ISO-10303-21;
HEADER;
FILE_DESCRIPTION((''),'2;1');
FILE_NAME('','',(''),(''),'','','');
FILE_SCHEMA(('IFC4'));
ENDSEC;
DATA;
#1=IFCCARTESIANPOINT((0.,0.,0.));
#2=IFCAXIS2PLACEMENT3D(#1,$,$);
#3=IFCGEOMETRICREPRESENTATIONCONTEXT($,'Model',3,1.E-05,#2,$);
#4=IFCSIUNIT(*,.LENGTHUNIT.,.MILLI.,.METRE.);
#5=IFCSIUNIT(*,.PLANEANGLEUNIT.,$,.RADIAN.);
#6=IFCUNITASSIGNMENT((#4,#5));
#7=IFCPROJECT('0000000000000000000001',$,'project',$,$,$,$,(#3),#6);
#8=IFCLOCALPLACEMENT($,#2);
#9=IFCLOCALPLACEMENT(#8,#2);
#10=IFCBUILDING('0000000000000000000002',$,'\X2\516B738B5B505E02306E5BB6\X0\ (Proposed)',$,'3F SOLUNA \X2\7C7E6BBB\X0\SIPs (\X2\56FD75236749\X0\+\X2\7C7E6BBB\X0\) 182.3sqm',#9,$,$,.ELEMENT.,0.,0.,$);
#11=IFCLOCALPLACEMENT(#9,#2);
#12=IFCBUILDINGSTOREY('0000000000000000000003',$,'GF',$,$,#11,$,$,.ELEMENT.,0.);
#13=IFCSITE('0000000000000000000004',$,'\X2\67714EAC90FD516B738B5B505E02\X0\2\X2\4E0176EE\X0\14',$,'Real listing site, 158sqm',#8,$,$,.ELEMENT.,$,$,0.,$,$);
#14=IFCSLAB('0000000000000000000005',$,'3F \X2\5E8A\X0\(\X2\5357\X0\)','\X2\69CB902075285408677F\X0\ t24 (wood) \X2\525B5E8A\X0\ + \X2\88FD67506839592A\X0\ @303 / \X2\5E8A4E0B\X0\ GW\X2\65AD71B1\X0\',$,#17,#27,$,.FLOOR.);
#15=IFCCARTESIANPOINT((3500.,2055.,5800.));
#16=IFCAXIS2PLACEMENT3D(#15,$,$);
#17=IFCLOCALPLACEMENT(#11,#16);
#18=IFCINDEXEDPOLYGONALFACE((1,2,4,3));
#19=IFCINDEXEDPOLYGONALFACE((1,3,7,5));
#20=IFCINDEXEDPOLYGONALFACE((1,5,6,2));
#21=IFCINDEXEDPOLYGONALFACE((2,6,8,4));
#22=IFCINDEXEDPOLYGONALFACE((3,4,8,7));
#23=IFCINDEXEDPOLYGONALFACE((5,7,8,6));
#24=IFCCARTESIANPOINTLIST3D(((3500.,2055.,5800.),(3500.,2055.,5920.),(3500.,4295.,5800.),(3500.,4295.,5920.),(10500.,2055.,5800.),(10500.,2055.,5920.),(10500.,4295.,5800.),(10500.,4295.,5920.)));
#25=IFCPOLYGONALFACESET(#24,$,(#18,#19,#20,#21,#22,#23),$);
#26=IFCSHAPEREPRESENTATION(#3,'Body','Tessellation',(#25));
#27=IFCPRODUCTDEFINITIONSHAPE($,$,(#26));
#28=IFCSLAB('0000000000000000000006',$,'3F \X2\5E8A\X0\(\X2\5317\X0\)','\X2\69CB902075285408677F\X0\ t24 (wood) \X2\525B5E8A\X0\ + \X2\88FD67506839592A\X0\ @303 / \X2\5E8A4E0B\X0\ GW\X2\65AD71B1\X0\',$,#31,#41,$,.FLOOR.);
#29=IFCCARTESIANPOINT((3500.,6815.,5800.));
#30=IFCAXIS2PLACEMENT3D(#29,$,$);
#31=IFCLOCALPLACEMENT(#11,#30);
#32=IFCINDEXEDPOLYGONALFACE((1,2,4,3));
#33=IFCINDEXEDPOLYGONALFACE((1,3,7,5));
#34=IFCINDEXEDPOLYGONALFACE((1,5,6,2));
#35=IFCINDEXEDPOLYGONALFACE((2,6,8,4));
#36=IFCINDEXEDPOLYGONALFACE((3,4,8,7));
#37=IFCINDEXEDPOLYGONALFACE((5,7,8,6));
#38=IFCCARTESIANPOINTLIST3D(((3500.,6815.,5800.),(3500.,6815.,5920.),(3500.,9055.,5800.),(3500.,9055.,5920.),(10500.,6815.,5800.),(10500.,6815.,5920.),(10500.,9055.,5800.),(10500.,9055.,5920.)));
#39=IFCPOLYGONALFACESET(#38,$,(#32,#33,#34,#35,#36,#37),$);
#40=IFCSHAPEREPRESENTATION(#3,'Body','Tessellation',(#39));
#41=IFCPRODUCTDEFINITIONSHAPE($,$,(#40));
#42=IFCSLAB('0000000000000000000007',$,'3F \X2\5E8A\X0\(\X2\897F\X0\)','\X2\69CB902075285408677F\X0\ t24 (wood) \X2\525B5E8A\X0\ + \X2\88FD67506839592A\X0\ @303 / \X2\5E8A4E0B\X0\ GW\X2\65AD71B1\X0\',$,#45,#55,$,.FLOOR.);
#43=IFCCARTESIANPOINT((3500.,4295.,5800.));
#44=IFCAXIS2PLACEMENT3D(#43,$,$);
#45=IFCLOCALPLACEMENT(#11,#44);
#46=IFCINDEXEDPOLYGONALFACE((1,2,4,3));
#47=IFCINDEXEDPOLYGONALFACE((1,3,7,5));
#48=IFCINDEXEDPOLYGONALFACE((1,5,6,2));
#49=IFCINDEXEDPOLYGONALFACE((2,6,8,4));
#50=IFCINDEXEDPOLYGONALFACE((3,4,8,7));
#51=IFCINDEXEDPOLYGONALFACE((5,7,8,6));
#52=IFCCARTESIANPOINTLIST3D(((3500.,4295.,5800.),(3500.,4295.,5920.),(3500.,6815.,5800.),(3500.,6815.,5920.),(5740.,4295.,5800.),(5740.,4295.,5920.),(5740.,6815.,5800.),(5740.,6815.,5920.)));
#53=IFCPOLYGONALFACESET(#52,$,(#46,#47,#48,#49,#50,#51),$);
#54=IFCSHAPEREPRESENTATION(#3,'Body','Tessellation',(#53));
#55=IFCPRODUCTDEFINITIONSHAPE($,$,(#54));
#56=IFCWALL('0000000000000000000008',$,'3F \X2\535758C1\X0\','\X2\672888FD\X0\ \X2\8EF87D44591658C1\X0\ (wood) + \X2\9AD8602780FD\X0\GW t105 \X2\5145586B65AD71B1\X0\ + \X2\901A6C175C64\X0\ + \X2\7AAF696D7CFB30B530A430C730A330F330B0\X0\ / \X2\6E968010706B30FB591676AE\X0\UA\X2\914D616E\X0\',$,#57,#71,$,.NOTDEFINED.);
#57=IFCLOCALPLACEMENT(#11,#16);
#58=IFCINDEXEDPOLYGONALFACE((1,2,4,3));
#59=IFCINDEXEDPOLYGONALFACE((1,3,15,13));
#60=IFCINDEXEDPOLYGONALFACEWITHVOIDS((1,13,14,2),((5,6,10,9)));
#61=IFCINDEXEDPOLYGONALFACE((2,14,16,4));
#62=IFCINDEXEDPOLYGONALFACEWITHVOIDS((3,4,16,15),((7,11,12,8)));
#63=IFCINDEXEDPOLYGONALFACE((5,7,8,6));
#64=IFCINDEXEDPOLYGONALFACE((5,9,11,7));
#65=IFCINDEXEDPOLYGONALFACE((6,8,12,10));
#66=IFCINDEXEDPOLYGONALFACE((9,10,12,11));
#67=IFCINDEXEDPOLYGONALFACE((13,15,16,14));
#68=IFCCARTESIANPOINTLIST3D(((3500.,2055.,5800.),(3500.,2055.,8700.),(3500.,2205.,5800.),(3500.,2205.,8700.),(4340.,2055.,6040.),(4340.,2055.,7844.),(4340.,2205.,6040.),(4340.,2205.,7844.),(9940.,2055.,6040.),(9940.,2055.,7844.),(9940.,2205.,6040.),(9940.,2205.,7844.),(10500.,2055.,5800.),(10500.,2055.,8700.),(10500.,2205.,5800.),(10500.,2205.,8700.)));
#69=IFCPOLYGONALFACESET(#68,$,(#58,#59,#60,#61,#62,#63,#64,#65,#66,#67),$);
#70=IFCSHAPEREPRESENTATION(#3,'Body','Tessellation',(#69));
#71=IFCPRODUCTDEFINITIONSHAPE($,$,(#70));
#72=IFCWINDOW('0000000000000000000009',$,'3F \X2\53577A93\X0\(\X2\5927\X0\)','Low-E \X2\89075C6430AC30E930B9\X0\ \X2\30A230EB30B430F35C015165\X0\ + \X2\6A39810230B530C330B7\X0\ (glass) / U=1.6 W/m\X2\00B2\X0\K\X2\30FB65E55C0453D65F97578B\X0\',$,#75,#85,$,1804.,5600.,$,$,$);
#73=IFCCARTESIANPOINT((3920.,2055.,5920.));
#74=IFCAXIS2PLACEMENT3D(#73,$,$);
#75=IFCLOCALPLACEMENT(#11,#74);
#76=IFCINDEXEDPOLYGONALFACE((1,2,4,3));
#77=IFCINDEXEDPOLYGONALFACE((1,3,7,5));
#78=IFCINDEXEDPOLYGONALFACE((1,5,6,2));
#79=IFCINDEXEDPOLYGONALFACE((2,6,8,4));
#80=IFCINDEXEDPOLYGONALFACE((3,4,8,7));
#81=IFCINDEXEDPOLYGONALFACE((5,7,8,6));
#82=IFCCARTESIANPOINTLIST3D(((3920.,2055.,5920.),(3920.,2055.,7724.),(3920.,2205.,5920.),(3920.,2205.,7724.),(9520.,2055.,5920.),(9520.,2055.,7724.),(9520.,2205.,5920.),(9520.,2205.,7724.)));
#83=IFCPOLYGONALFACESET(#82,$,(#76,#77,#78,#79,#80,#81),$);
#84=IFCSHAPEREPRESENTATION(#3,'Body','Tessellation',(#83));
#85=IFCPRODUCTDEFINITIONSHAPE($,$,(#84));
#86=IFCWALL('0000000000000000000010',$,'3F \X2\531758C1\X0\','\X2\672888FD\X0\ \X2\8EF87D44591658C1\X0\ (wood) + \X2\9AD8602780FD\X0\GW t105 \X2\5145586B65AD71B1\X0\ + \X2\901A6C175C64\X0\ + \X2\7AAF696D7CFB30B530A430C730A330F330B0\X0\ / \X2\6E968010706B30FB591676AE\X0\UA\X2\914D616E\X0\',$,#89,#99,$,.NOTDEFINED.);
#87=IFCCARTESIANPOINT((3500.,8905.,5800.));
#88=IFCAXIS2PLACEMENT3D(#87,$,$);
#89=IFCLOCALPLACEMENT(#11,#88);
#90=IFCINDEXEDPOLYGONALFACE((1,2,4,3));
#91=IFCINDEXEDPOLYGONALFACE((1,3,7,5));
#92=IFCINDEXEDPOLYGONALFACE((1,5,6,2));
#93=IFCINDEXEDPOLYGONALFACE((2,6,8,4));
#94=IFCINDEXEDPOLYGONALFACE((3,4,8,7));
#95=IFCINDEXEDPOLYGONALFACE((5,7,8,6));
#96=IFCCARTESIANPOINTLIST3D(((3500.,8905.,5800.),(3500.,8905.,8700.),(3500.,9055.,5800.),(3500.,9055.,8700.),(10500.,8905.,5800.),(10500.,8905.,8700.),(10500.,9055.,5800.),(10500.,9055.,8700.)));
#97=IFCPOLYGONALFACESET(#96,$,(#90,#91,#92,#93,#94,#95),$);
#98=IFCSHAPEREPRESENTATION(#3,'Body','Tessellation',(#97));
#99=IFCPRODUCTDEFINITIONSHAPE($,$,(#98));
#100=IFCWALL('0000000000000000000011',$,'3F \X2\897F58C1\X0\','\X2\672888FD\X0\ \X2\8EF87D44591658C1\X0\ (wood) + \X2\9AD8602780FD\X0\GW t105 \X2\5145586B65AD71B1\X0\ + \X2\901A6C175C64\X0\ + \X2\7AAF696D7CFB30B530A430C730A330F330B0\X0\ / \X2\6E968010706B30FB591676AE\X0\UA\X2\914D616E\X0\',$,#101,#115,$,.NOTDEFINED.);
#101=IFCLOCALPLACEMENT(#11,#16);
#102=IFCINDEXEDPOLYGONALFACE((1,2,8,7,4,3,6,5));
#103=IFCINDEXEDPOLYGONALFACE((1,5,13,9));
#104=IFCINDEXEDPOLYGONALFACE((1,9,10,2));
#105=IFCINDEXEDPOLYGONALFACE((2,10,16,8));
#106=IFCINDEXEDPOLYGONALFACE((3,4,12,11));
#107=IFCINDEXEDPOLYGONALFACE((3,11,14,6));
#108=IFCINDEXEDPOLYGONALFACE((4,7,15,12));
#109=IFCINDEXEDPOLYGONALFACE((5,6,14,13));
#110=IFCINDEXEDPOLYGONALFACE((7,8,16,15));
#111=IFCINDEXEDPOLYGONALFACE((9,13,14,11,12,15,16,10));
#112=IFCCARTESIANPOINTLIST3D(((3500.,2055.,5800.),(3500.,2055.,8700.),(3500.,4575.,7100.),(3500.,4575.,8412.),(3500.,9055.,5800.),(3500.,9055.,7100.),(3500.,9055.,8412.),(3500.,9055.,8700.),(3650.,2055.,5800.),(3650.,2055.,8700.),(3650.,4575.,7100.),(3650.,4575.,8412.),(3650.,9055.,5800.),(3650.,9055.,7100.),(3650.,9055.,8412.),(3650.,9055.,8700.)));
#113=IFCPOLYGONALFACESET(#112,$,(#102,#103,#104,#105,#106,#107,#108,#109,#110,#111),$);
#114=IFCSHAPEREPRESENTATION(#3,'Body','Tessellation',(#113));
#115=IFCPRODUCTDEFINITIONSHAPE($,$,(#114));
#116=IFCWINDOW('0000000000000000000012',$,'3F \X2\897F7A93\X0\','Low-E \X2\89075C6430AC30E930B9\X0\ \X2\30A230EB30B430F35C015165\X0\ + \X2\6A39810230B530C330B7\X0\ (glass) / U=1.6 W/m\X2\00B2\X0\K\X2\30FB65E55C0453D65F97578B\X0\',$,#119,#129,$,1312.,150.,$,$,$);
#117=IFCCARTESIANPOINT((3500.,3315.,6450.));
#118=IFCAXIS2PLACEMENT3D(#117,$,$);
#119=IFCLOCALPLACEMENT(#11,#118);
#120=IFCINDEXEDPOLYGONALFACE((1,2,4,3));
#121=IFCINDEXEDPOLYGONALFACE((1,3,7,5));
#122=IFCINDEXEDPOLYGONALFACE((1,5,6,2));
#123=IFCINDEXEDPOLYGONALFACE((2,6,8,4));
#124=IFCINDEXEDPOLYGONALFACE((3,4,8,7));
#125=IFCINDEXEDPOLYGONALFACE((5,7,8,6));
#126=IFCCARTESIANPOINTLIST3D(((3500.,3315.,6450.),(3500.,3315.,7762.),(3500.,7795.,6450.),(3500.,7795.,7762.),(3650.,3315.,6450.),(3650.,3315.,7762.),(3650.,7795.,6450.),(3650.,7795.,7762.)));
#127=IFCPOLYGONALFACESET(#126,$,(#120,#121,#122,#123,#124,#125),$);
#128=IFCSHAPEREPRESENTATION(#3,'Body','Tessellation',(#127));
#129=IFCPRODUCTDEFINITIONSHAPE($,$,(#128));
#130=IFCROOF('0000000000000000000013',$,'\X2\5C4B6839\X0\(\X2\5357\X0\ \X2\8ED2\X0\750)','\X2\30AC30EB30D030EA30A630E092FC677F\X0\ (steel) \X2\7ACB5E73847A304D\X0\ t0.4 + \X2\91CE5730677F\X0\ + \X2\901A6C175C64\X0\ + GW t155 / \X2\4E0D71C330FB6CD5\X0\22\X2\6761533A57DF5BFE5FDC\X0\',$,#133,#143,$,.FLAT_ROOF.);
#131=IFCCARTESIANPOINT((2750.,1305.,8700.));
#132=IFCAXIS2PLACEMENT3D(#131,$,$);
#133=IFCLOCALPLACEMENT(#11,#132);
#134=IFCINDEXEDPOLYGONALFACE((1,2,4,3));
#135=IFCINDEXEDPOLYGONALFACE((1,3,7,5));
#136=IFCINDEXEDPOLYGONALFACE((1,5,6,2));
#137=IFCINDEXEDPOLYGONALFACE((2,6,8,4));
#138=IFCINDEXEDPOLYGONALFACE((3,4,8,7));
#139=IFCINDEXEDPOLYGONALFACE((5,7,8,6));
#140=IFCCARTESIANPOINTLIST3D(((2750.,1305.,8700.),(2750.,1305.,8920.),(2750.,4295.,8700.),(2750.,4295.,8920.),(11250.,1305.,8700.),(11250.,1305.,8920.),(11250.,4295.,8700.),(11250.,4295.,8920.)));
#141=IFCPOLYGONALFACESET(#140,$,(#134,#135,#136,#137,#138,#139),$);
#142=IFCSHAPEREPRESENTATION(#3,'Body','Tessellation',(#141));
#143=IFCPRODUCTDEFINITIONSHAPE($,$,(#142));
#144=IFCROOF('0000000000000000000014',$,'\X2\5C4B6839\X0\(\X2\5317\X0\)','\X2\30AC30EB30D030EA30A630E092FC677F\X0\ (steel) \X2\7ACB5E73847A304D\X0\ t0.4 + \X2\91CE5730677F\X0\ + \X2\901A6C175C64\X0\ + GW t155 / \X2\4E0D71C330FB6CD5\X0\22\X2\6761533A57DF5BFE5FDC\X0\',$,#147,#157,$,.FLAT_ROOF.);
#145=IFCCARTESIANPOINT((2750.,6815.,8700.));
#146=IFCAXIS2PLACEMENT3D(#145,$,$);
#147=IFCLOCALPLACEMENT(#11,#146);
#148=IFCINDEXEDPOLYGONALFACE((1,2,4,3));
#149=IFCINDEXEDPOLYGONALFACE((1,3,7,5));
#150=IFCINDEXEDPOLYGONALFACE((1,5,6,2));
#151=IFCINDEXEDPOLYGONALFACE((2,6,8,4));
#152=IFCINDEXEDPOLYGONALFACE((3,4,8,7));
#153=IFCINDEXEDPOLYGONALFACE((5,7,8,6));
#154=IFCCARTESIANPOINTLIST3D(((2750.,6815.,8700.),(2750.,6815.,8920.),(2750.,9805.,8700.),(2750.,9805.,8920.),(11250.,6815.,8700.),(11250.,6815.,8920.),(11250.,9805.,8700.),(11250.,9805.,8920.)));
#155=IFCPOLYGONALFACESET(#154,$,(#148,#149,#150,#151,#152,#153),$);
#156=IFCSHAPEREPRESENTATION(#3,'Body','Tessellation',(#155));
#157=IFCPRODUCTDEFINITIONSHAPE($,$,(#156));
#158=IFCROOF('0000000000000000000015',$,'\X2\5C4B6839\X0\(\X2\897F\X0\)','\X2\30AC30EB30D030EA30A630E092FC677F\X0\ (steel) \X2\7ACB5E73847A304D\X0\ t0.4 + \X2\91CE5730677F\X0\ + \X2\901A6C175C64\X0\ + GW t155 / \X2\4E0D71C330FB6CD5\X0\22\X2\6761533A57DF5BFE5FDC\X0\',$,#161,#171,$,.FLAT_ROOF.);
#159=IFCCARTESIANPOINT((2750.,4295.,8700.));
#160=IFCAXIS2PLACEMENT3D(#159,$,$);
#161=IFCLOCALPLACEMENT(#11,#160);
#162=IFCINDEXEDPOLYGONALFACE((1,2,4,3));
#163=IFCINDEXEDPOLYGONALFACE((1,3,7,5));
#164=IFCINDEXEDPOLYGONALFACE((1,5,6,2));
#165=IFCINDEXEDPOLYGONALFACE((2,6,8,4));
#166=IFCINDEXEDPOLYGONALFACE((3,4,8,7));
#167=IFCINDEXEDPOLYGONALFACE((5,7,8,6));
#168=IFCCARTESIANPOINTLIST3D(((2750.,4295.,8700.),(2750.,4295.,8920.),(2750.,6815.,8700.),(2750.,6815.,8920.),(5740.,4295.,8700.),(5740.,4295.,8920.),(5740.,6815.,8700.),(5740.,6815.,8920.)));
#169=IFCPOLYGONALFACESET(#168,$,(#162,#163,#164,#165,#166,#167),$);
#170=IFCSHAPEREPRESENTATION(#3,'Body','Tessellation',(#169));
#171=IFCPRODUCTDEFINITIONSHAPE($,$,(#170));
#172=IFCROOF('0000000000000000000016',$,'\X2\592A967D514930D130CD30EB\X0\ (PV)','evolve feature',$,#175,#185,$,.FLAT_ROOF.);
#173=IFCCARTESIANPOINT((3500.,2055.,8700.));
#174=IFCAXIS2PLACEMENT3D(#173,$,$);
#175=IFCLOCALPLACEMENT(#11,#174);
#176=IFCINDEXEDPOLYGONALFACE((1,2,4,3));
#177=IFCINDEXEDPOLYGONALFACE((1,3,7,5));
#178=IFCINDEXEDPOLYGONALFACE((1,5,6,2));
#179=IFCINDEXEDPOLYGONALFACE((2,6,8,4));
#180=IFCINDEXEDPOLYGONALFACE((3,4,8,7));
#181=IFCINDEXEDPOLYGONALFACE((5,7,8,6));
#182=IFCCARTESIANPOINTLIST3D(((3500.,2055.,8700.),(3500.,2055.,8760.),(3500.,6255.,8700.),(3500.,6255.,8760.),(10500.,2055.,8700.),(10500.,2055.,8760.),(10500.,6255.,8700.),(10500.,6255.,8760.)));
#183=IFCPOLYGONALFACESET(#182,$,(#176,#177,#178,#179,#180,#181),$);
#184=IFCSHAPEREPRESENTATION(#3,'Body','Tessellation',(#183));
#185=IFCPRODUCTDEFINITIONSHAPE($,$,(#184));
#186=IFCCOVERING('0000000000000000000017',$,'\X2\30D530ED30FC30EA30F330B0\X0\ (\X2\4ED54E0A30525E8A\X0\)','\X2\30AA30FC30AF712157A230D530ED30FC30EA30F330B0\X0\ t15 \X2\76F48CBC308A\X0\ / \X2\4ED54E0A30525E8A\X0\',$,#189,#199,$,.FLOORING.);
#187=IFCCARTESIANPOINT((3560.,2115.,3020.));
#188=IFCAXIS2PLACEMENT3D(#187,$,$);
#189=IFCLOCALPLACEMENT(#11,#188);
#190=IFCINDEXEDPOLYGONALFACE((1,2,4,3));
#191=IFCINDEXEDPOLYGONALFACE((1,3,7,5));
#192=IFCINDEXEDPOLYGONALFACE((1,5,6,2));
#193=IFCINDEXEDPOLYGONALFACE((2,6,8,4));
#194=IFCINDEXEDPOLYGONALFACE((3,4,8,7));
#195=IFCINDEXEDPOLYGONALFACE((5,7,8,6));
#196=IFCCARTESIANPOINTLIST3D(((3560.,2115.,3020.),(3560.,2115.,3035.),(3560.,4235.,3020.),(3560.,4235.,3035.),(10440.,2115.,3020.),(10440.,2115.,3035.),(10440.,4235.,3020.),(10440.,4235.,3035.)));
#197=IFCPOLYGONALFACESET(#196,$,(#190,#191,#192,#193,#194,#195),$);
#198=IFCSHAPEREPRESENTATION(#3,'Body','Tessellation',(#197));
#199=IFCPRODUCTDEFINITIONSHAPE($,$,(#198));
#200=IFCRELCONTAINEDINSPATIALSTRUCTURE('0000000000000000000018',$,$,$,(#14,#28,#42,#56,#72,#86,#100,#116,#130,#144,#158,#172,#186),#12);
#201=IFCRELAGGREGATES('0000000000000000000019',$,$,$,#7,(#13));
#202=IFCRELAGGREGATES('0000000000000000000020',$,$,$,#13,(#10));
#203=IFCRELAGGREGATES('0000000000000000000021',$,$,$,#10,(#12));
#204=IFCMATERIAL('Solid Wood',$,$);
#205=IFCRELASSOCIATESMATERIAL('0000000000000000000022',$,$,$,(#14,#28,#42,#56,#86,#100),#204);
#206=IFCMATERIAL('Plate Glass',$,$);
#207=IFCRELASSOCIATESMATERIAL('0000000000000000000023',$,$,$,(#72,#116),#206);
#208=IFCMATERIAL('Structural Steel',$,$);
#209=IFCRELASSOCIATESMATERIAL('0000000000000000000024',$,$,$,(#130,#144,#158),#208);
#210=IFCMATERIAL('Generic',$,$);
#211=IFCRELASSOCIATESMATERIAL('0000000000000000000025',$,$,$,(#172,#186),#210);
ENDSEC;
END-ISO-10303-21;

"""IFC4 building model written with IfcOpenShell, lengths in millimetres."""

from ifc_helpers import new_model, si_unit, frame, frame_2d, origin, place, context, project, spatial, rectangle, extrude, material, element, fill, save


model = new_model("IFC4")

# Units and contexts
model_context = context("Model", 3, precision=1e-05, world=origin())
ifc_project = project(units=[si_unit("LENGTHUNIT", "METRE", prefix="MILLI"), si_unit("PLANEANGLEUNIT", "RADIAN")], contexts=[model_context])

# Site, building, storey
site_placement = place(None, origin())
site = spatial("IfcSite", under=ifc_project, at=site_placement, Name="東京都八王子市2丁目14", ObjectType="Real listing site, 158sqm", CompositionType="ELEMENT", RefElevation=0.0)
building_placement = place(site_placement, origin())
building = spatial("IfcBuilding", under=site, at=building_placement, Name="八王子市の家 (Proposed)", ObjectType="3F SOLUNA 籾殻SIPs (国産杉+籾殻) 182.3sqm", CompositionType="ELEMENT", ElevationOfRefHeight=0.0, ElevationOfTerrain=0.0)
storey_placement = place(building_placement, origin())
storey = spatial("IfcBuildingStorey", under=building, at=storey_placement, Name="GF", CompositionType="ELEMENT", Elevation=0.0)

# Slabs
ifc_material_1 = material(Name="Solid Wood")
slab_1_placement = place(storey_placement, frame((3500.0, 2055.0, 5800.0)))
element("IfcSlab", 1, at=slab_1_placement, inside=storey, material=ifc_material_1, Name="3F 床(南)", Description="構造用合板 t24 (wood) 剛床 + 製材根太 @303 / 床下 GW断熱", PredefinedType="FLOOR", context=model_context, shape_type="SweptSolid", body=[
    extrude(rectangle(XDim=7000.0, YDim=2240.0, at=frame_2d((3500.0, 1120.0))), frame((3500.0, 2055.0, 5800.0)), (0.0, 0.0, 1.0), 120.0),
])
slab_2_placement = place(storey_placement, frame((3500.0, 6815.0, 5800.0)))
element("IfcSlab", 2, at=slab_2_placement, inside=storey, material=ifc_material_1, Name="3F 床(北)", Description="構造用合板 t24 (wood) 剛床 + 製材根太 @303 / 床下 GW断熱", PredefinedType="FLOOR", context=model_context, shape_type="SweptSolid", body=[
    extrude(rectangle(XDim=7000.0, YDim=2240.0, at=frame_2d((3500.0, 1120.0))), frame((3500.0, 6815.0, 5800.0)), (0.0, 0.0, 1.0), 120.0),
])
slab_3_placement = place(storey_placement, frame((3500.0, 4295.0, 5800.0)))
element("IfcSlab", 3, at=slab_3_placement, inside=storey, material=ifc_material_1, Name="3F 床(西)", Description="構造用合板 t24 (wood) 剛床 + 製材根太 @303 / 床下 GW断熱", PredefinedType="FLOOR", context=model_context, shape_type="SweptSolid", body=[
    extrude(rectangle(XDim=2240.0, YDim=2520.0, at=frame_2d((1120.0, 1260.0))), frame((3500.0, 4295.0, 5800.0)), (0.0, 0.0, 1.0), 120.0),
])

# Wall, opening, window
wall_1_placement = place(storey_placement, frame((3500.0, 2055.0, 5800.0)))
wall_1 = element("IfcWall", 4, at=wall_1_placement, inside=storey, material=ifc_material_1, Name="3F 南壁", Description="木製 軸組外壁 (wood) + 高性能GW t105 充填断熱 + 通気層 + 窯業系サイディング / 準耐火・外皮UA配慮", PredefinedType="NOTDEFINED", context=model_context, shape_type="SweptSolid", body=[
    extrude(rectangle(XDim=7000.0, YDim=150.0, at=frame_2d((3500.0, 75.0))), frame((3500.0, 2055.0, 5800.0)), (0.0, 0.0, 1.0), 2900.0),
])
opening_1_placement = place(storey_placement, frame((3920.0, 2055.0, 5920.0)))
opening_1 = element("IfcOpeningElement", 5, at=opening_1_placement, cuts=wall_1, PredefinedType="NOTDEFINED", context=model_context, shape_type="SweptSolid", body=[
    extrude(rectangle(XDim=5600.0, YDim=150.0, at=frame_2d((2800.0, 75.0))), frame((3920.0, 2055.0, 5920.0)), (0.0, 0.0, 1.0), 1804.0),
])
ifc_material_2 = material(Name="Plate Glass")
window_1_placement = place(storey_placement, frame((3920.0, 2055.0, 5920.0)))
window_1 = element("IfcWindow", 6, at=window_1_placement, inside=storey, material=ifc_material_2, Name="3F 南窓(大)", Description="Low-E 複層ガラス アルゴン封入 + 樹脂サッシ (glass) / U=1.6 W/m²K・日射取得型", OverallHeight=1804.0, OverallWidth=5600.0, context=model_context, shape_type="SweptSolid", body=[
    extrude(rectangle(XDim=5600.0, YDim=150.0, at=frame_2d((2800.0, 75.0))), frame((3920.0, 2055.0, 5920.0)), (0.0, 0.0, 1.0), 1804.0),
])
fill(opening_1, window_1)

# Wall
wall_2_placement = place(storey_placement, frame((3500.0, 8905.0, 5800.0)))
element("IfcWall", 7, at=wall_2_placement, inside=storey, material=ifc_material_1, Name="3F 北壁", Description="木製 軸組外壁 (wood) + 高性能GW t105 充填断熱 + 通気層 + 窯業系サイディング / 準耐火・外皮UA配慮", PredefinedType="NOTDEFINED", context=model_context, shape_type="SweptSolid", body=[
    extrude(rectangle(XDim=7000.0, YDim=150.0, at=frame_2d((3500.0, 75.0))), frame((3500.0, 8905.0, 5800.0)), (0.0, 0.0, 1.0), 2900.0),
])

# Wall, opening, window
wall_3_placement = place(storey_placement, frame((3500.0, 2055.0, 5800.0)))
wall_3 = element("IfcWall", 8, at=wall_3_placement, inside=storey, material=ifc_material_1, Name="3F 西壁", Description="木製 軸組外壁 (wood) + 高性能GW t105 充填断熱 + 通気層 + 窯業系サイディング / 準耐火・外皮UA配慮", PredefinedType="NOTDEFINED", context=model_context, shape_type="SweptSolid", body=[
    extrude(rectangle(XDim=150.0, YDim=7000.0, at=frame_2d((75.0, 3500.0))), frame((3500.0, 2055.0, 5800.0)), (0.0, 0.0, 1.0), 2900.0),
])
opening_2_placement = place(storey_placement, frame((3500.0, 3315.0, 6450.0)))
opening_2 = element("IfcOpeningElement", 9, at=opening_2_placement, cuts=wall_3, PredefinedType="NOTDEFINED", context=model_context, shape_type="SweptSolid", body=[
    extrude(rectangle(XDim=150.0, YDim=4480.0, at=frame_2d((75.0, 2240.0))), frame((3500.0, 3315.0, 6450.0)), (0.0, 0.0, 1.0), 1312.0),
])
window_2_placement = place(storey_placement, frame((3500.0, 3315.0, 6450.0)))
window_2 = element("IfcWindow", 10, at=window_2_placement, inside=storey, material=ifc_material_2, Name="3F 西窓", Description="Low-E 複層ガラス アルゴン封入 + 樹脂サッシ (glass) / U=1.6 W/m²K・日射取得型", OverallHeight=1312.0, OverallWidth=150.0, context=model_context, shape_type="SweptSolid", body=[
    extrude(rectangle(XDim=150.0, YDim=4480.0, at=frame_2d((75.0, 2240.0))), frame((3500.0, 3315.0, 6450.0)), (0.0, 0.0, 1.0), 1312.0),
])
fill(opening_2, window_2)

# Roofs
ifc_material_3 = material(Name="Structural Steel")
roof_1_placement = place(storey_placement, frame((2750.0, 1305.0, 8700.0)))
element("IfcRoof", 11, at=roof_1_placement, inside=storey, material=ifc_material_3, Name="屋根(南 軒750)", Description="ガルバリウム鋼板 (steel) 立平葺き t0.4 + 野地板 + 通気層 + GW t155 / 不燃・法22条区域対応", PredefinedType="FLAT_ROOF", context=model_context, shape_type="SweptSolid", body=[
    extrude(rectangle(XDim=8500.0, YDim=2990.0, at=frame_2d((4250.0, 1495.0))), frame((2750.0, 1305.0, 8700.0)), (0.0, 0.0, 1.0), 220.0),
])
roof_2_placement = place(storey_placement, frame((2750.0, 6815.0, 8700.0)))
element("IfcRoof", 12, at=roof_2_placement, inside=storey, material=ifc_material_3, Name="屋根(北)", Description="ガルバリウム鋼板 (steel) 立平葺き t0.4 + 野地板 + 通気層 + GW t155 / 不燃・法22条区域対応", PredefinedType="FLAT_ROOF", context=model_context, shape_type="SweptSolid", body=[
    extrude(rectangle(XDim=8500.0, YDim=2990.0, at=frame_2d((4250.0, 1495.0))), frame((2750.0, 6815.0, 8700.0)), (0.0, 0.0, 1.0), 220.0),
])
roof_3_placement = place(storey_placement, frame((2750.0, 4295.0, 8700.0)))
element("IfcRoof", 13, at=roof_3_placement, inside=storey, material=ifc_material_3, Name="屋根(西)", Description="ガルバリウム鋼板 (steel) 立平葺き t0.4 + 野地板 + 通気層 + GW t155 / 不燃・法22条区域対応", PredefinedType="FLAT_ROOF", context=model_context, shape_type="SweptSolid", body=[
    extrude(rectangle(XDim=2990.0, YDim=2520.0, at=frame_2d((1495.0, 1260.0))), frame((2750.0, 4295.0, 8700.0)), (0.0, 0.0, 1.0), 220.0),
])
ifc_material_4 = material(Name="Generic")
roof_4_placement = place(storey_placement, frame((3500.0, 2055.0, 8700.0)))
element("IfcRoof", 14, at=roof_4_placement, inside=storey, material=ifc_material_4, Name="太陽光パネル (PV)", Description="evolve feature", PredefinedType="FLAT_ROOF", context=model_context, shape_type="SweptSolid", body=[
    extrude(rectangle(XDim=7000.0, YDim=4200.0, at=frame_2d((3500.0, 2100.0))), frame((3500.0, 2055.0, 8700.0)), (0.0, 0.0, 1.0), 60.0),
])

# Covering
covering_1_placement = place(storey_placement, frame((3560.0, 2115.0, 3020.0)))
element("IfcCovering", 15, at=covering_1_placement, inside=storey, material=ifc_material_4, Name="フローリング (仕上げ床)", Description="オーク無垢フローリング t15 直貼り / 仕上げ床", PredefinedType="FLOORING", context=model_context, shape_type="SweptSolid", body=[
    extrude(rectangle(XDim=6880.0, YDim=2120.0, at=frame_2d((3440.0, 1060.0))), frame((3560.0, 2115.0, 3020.0)), (0.0, 0.0, 1.0), 15.0),
])

save(model, "model.ifc")
